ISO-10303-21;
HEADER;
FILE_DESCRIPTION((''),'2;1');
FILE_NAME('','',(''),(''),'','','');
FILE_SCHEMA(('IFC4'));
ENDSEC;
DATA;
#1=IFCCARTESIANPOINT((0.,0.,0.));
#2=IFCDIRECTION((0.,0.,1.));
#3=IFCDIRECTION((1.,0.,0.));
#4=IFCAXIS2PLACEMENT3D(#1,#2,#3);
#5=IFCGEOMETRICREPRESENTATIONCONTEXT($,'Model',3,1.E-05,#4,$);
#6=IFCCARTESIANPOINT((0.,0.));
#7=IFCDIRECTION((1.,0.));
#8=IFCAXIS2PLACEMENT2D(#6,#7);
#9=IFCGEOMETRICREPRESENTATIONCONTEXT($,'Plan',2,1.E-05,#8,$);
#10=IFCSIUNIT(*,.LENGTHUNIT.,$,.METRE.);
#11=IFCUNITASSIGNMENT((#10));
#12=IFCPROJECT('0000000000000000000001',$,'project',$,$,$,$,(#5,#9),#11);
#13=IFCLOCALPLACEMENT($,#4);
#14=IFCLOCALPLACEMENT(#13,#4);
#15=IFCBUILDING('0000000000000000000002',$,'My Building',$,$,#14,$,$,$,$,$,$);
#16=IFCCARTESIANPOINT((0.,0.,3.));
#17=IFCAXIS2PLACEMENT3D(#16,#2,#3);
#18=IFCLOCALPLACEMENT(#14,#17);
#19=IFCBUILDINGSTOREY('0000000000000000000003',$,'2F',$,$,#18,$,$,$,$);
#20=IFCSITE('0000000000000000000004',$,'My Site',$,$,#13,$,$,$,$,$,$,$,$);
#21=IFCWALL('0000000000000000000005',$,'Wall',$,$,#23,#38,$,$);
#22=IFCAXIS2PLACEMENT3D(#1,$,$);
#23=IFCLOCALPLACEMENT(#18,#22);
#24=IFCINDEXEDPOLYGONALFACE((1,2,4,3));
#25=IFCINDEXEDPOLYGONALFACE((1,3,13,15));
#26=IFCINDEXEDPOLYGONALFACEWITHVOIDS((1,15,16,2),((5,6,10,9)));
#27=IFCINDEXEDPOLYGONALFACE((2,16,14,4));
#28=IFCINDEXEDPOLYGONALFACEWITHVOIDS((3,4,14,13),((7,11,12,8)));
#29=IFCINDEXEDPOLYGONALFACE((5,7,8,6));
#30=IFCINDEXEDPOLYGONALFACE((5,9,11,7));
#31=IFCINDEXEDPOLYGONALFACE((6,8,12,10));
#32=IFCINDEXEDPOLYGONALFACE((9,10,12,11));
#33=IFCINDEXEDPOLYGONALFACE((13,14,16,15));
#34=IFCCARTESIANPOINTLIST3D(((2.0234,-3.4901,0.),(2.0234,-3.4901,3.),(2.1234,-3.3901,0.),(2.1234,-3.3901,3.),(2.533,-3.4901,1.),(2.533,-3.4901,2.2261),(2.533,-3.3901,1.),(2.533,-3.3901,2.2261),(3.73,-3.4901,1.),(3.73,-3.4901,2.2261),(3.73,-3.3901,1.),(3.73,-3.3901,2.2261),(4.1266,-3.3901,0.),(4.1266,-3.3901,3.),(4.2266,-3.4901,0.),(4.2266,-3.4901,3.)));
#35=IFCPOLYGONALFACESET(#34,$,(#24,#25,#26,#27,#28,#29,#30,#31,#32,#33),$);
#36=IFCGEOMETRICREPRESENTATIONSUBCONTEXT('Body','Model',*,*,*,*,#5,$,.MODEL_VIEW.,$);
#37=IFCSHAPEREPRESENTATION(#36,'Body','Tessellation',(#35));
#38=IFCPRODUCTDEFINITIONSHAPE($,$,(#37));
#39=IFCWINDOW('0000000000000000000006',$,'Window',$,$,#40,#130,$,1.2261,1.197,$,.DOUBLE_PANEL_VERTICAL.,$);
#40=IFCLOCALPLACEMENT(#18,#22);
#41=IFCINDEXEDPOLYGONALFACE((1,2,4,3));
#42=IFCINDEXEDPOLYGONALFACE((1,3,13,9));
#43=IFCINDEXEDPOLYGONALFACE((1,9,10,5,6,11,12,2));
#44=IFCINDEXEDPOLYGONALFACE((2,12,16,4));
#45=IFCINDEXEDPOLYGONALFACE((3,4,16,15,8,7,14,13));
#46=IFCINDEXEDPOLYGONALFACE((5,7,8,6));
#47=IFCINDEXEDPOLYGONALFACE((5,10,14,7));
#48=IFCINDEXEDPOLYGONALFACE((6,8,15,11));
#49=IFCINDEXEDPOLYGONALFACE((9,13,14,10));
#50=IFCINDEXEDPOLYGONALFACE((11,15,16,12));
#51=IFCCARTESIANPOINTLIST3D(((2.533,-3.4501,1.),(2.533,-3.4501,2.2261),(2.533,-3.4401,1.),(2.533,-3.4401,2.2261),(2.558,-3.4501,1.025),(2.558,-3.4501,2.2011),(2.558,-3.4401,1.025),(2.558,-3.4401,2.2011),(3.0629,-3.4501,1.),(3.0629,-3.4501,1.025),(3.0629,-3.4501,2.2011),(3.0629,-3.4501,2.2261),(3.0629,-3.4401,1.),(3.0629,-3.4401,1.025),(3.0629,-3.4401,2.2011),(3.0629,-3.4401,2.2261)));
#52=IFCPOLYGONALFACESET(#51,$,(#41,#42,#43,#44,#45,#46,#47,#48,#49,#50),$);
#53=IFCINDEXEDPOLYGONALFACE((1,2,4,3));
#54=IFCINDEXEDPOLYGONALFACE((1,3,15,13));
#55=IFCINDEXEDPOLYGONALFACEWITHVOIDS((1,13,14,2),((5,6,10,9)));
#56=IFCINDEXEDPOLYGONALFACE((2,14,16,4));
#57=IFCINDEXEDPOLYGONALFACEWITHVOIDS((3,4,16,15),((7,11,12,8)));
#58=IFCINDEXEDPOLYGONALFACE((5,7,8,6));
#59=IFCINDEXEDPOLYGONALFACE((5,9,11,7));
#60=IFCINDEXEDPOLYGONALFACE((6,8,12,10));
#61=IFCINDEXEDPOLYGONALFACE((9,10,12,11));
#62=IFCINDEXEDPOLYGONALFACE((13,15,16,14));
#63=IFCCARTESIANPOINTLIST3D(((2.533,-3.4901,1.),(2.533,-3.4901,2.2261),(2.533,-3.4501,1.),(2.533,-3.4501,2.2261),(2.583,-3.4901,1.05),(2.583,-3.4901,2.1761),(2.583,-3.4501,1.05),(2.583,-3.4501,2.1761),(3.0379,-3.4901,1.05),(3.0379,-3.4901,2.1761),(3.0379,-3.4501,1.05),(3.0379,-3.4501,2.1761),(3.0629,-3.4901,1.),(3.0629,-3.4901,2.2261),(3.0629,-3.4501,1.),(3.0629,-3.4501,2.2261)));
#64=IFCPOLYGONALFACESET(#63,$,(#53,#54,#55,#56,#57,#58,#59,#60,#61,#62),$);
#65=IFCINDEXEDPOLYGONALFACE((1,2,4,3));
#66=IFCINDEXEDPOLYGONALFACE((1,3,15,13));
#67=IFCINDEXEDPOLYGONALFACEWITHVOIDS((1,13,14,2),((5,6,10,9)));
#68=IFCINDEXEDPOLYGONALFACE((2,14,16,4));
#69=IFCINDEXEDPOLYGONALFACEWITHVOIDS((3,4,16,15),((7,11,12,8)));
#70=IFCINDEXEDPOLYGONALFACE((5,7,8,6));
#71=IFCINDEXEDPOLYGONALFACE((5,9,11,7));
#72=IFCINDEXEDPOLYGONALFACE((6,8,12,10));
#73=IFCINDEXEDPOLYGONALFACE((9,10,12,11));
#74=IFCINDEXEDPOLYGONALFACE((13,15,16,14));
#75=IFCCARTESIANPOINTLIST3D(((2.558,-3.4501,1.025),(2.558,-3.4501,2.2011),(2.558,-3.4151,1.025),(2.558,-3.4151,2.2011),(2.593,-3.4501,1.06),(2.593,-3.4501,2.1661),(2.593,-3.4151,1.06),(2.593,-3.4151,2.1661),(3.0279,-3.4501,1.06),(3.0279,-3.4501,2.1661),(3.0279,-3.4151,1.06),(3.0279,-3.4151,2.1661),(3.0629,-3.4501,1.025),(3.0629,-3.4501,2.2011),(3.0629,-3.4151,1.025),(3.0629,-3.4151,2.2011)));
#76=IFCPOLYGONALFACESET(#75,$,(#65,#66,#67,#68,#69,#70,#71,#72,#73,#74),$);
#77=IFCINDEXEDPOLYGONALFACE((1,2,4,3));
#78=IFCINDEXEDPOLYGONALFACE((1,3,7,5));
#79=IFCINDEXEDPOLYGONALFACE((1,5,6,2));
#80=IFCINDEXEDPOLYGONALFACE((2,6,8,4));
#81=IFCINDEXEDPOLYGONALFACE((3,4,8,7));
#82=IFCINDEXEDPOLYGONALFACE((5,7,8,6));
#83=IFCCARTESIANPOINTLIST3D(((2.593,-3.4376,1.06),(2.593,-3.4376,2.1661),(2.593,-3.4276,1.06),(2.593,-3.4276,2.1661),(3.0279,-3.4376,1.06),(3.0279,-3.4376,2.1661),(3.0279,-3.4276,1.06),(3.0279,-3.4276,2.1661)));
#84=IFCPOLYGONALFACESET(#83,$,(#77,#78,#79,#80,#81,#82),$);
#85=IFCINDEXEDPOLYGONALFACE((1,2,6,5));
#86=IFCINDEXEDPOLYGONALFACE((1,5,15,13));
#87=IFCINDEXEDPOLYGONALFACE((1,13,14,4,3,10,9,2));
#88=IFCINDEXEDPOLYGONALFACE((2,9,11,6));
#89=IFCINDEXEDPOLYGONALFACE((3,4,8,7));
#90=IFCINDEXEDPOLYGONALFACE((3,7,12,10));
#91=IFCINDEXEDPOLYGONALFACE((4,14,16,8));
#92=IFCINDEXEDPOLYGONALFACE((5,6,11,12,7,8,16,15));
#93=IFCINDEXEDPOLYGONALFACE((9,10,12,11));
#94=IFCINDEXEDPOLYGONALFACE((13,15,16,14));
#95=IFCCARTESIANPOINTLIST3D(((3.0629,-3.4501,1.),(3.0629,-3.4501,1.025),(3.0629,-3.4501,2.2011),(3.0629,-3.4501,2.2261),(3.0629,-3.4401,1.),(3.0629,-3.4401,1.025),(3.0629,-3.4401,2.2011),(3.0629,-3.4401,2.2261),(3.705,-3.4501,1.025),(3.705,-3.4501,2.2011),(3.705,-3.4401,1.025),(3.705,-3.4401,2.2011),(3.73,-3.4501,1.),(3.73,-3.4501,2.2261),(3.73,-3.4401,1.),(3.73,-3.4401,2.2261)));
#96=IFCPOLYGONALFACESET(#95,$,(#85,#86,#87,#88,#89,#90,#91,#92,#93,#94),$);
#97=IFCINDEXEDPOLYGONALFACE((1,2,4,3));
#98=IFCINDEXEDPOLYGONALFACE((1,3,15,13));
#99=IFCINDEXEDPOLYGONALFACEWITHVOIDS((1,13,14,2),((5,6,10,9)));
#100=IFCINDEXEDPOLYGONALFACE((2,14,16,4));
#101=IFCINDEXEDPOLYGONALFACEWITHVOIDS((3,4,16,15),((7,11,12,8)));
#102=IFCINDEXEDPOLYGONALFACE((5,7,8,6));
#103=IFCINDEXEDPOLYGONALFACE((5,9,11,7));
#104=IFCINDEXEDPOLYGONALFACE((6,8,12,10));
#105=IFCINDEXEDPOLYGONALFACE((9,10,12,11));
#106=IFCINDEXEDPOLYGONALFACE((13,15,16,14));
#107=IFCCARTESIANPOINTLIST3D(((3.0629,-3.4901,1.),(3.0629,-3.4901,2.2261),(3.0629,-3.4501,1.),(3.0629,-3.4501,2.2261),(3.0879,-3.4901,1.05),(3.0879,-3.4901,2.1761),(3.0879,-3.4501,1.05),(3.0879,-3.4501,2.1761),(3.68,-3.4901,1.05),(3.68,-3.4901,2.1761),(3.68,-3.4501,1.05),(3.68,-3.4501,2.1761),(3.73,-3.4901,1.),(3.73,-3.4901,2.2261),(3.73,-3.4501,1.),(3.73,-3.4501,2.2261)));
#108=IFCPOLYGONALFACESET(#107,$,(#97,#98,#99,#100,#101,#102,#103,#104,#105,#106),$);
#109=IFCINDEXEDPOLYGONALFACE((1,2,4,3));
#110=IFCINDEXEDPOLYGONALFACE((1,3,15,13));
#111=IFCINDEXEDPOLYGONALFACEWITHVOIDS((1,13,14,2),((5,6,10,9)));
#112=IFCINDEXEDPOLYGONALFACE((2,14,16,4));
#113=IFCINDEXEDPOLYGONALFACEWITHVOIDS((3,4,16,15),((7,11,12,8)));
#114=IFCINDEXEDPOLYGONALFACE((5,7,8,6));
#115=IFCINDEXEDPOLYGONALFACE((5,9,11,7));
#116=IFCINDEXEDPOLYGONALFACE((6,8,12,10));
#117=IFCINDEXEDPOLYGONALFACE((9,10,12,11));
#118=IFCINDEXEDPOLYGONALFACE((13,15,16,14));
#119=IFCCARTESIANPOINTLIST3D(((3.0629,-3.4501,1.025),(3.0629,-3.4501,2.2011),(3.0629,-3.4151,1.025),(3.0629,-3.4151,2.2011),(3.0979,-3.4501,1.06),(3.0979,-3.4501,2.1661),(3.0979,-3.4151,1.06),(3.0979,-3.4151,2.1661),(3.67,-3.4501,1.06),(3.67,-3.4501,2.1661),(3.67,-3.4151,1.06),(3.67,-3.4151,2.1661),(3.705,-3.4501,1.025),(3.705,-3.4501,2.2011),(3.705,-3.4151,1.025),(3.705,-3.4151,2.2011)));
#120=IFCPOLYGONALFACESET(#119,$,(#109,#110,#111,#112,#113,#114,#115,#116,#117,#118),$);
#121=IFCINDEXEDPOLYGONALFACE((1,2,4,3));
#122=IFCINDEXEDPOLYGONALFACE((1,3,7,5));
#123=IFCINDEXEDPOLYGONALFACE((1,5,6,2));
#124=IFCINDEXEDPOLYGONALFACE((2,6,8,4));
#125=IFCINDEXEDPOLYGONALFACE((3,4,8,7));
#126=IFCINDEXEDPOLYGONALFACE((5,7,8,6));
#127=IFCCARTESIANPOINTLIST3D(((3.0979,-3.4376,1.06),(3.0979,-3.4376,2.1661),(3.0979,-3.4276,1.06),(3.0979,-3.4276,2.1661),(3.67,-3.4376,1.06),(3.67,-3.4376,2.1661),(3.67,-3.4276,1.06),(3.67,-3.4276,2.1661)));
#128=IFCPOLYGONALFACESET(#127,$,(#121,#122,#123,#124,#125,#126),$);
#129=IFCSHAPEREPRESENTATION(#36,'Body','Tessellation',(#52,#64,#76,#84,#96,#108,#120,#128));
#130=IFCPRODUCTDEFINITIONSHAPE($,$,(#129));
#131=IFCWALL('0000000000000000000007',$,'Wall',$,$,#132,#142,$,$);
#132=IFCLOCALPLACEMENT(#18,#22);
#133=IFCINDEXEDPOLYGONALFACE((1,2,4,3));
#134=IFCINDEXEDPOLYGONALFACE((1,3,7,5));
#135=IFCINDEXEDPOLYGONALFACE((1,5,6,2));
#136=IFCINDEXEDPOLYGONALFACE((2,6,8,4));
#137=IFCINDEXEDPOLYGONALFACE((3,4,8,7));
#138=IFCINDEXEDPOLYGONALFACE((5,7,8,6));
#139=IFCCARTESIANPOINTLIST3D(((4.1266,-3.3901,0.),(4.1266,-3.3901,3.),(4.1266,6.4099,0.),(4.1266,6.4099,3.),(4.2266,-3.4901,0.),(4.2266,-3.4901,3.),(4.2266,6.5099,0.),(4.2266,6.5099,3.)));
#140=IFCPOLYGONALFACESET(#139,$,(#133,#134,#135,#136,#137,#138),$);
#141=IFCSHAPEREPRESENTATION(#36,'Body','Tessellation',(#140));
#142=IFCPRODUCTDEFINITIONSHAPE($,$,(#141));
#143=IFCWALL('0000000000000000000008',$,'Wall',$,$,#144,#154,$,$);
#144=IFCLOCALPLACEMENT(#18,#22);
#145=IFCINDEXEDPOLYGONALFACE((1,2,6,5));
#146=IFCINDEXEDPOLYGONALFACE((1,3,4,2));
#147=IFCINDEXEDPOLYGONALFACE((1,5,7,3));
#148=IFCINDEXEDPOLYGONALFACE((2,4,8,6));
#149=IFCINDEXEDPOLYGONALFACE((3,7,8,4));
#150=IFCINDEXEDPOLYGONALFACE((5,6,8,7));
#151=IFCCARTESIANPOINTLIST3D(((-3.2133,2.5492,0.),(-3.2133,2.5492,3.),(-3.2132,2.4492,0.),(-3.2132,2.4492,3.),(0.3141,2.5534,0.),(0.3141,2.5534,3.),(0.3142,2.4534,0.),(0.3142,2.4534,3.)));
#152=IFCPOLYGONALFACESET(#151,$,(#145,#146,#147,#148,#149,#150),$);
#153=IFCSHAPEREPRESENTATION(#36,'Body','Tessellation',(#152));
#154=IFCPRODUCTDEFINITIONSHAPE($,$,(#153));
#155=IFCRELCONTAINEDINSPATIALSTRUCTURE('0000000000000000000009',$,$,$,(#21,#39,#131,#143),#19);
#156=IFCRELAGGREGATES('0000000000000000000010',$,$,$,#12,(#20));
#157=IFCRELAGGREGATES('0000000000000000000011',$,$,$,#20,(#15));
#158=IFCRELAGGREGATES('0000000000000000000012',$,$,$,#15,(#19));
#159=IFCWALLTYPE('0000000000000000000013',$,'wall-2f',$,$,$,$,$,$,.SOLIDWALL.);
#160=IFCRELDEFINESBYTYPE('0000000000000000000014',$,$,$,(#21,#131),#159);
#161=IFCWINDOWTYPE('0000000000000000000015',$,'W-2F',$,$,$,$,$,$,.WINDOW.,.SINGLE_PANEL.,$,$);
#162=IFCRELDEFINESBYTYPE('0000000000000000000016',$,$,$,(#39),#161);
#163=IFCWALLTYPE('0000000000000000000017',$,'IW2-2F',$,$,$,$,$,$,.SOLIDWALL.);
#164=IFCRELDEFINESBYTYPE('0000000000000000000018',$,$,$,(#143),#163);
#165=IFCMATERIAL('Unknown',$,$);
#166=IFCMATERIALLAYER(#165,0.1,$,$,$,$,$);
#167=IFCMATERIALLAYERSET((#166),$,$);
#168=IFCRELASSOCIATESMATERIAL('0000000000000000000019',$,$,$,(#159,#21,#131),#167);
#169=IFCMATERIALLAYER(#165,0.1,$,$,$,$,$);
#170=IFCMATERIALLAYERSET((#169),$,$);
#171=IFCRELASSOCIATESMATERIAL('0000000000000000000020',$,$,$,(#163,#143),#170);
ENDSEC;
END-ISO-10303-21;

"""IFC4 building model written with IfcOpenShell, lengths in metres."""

from ifc_helpers import new_model, entity, si_unit, frame, origin_with_axes, origin_2d_with_axis, place, context, subcontext, project, spatial, line, indexed_curve, outline, extrude, shape, source, transform, mapped, material, layer, layer_set, layer_usage, type_object, type_shapes, element, fill, save


model = new_model("IFC4")

# Units and contexts
model_context = context("Model", 3, precision=1e-05, world=origin_with_axes())
plan_context = context("Plan", 2, precision=1e-05, world=origin_2d_with_axis())
body_context_1 = subcontext(model_context, "Body", "Model", "MODEL_VIEW")
body_context_2 = subcontext(plan_context, "Body", "Plan", "PLAN_VIEW")
ifc_project = project(units=[si_unit("LENGTHUNIT", "METRE")], contexts=[model_context, plan_context])

# Site, building, storey
site_placement = place(None, origin_with_axes())
site = spatial("IfcSite", under=ifc_project, at=site_placement, Name="My Site")
building_placement = place(site_placement, origin_with_axes())
building = spatial("IfcBuilding", under=site, at=building_placement, Name="My Building")
storey_placement = place(building_placement, frame((0.0, 0.0, 3.0), z_axis=(0.0, 0.0, 1.0), x_axis=(1.0, 0.0, 0.0)))
storey = spatial("IfcBuildingStorey", under=building, at=storey_placement, Name="2F")

# Shared definitions
ifc_material = material(Name="Unknown")
ifc_layer_1 = layer(ifc_material, 0.1)
ifc_layer_set_1 = layer_set([ifc_layer_1])
wall_type_1 = type_object("IfcWallType", Name="wall-2f", PredefinedType="SOLIDWALL", material=ifc_layer_set_1)

# Wall, opening, window
ifc_layer_usage_1 = layer_usage(ifc_layer_set_1, "AXIS2", "POSITIVE", 0.0)
wall_1_placement = place(storey_placement, frame((2.0234, -3.4901, 0.0), z_axis=(0.0, 0.0, 1.0), x_axis=(1.0, 0.0, 0.0)))
wall_1 = element("IfcWall", 1, at=wall_1_placement, inside=storey, type_object=wall_type_1, material=ifc_layer_usage_1, Name="Wall", context=body_context_1, shape_type="SweptSolid", body=[
    extrude(outline(indexed_curve([(0.0, 0.0), (0.1, 0.1), (2.1032, 0.1), (2.2032, 0.0)], segments=[line(1, 2, 3, 4, 1)])), origin_with_axes(), (0.0, 0.0, 1.0), 3.0),
])
shared_shape_1 = source(origin_with_axes(), body_context_1, "Body", "SweptSolid", [
    extrude(outline(indexed_curve([(0.0, 0.0), (1.197, 0.0), (1.197, 1.2261), (0.0, 1.2261)], segments=[line(1, 2, 3, 4, 1)])), frame((0.0, -0.6, 0.0), z_axis=(0.0, -1.0, 0.0), x_axis=(1.0, 0.0, 0.0)), (0.0, 0.0, -1.0), 1.2),
])
opening_1_placement = place(wall_1_placement, frame((0.5096, -0.05, 1.0), z_axis=(0.0, 0.0, 1.0), x_axis=(1.0, 0.0, 0.0)))
opening_1 = element("IfcOpeningElement", 2, at=opening_1_placement, cuts=wall_1, PredefinedType="OPENING", context=body_context_1, shape_type="MappedRepresentation", body=[
    mapped(shared_shape_1, transform((0.0, 0.0, 0.0), x_axis=(1.0, 0.0, 0.0), y_axis=(0.0, 1.0, 0.0), z_axis=(0.0, 0.0, 1.0), scale=1.0)),
])
window_type_1 = type_object("IfcWindowType", Name="W-2F", PartitioningType="SINGLE_PANEL", PredefinedType="WINDOW")
shared_shape_2 = source(origin_with_axes(), body_context_1, "Body", "SweptSolid", [
    extrude(outline(indexed_curve([(0.5299, 0.0), (0.0, 0.0), (0.0, 1.2261), (0.5299, 1.2261), (0.5299, 1.2011), (0.025, 1.2011), (0.025, 0.025), (0.5299, 0.025)], segments=[line(1, 2, 3, 4, 5, 6, 7, 8, 1)])), frame((0.0, 0.09, 0.0), z_axis=(0.0, -1.0, 0.0), x_axis=(1.0, 0.0, 0.0)), (0.0, 0.0, -1.0), 0.01),
    extrude(outline(indexed_curve([(0.0, 0.0), (0.5299, 0.0), (0.5299, 1.2261), (0.0, 1.2261)], segments=[line(1, 2, 3, 4, 1)]), holes=[indexed_curve([(0.05, 0.05), (0.5049, 0.05), (0.5049, 1.1761), (0.05, 1.1761)], segments=[line(1, 2, 3, 4, 1)])]), frame((0.0, 0.05, 0.0), z_axis=(0.0, -1.0, 0.0), x_axis=(1.0, 0.0, 0.0)), (0.0, 0.0, -1.0), 0.04),
    extrude(outline(indexed_curve([(0.0, 0.0), (0.5049, 0.0), (0.5049, 1.1761), (0.0, 1.1761)], segments=[line(1, 2, 3, 4, 1)]), holes=[indexed_curve([(0.035, 0.035), (0.4699, 0.035), (0.4699, 1.1411), (0.035, 1.1411)], segments=[line(1, 2, 3, 4, 1)])]), frame((0.025, 0.09, 0.025), z_axis=(0.0, -1.0, 0.0), x_axis=(1.0, 0.0, 0.0)), (0.0, 0.0, -1.0), 0.035),
    extrude(outline(indexed_curve([(0.035, 0.035), (0.4699, 0.035), (0.4699, 1.1411), (0.035, 1.1411)], segments=[line(1, 2, 3, 4, 1)])), frame((0.025, 0.1025, 0.025), z_axis=(0.0, -1.0, 0.0), x_axis=(1.0, 0.0, 0.0)), (0.0, 0.0, -1.0), 0.01),
    extrude(outline(indexed_curve([(0.0, 1.2261), (0.6671, 1.2261), (0.6671, 0.0), (0.0, 0.0), (0.0, 0.025), (0.6421, 0.025), (0.6421, 1.2011), (0.0, 1.2011)], segments=[line(1, 2, 3, 4, 5, 6, 7, 8, 1)])), frame((0.5299, 0.09, 0.0), z_axis=(0.0, -1.0, 0.0), x_axis=(1.0, 0.0, 0.0)), (0.0, 0.0, -1.0), 0.01),
    extrude(outline(indexed_curve([(0.0, 0.0), (0.6671, 0.0), (0.6671, 1.2261), (0.0, 1.2261)], segments=[line(1, 2, 3, 4, 1)]), holes=[indexed_curve([(0.025, 0.05), (0.6171, 0.05), (0.6171, 1.1761), (0.025, 1.1761)], segments=[line(1, 2, 3, 4, 1)])]), frame((0.5299, 0.05, 0.0), z_axis=(0.0, -1.0, 0.0), x_axis=(1.0, 0.0, 0.0)), (0.0, 0.0, -1.0), 0.04),
    extrude(outline(indexed_curve([(0.0, 0.0), (0.6421, 0.0), (0.6421, 1.1761), (0.0, 1.1761)], segments=[line(1, 2, 3, 4, 1)]), holes=[indexed_curve([(0.035, 0.035), (0.6071, 0.035), (0.6071, 1.1411), (0.035, 1.1411)], segments=[line(1, 2, 3, 4, 1)])]), frame((0.5299, 0.09, 0.025), z_axis=(0.0, -1.0, 0.0), x_axis=(1.0, 0.0, 0.0)), (0.0, 0.0, -1.0), 0.035),
    extrude(outline(indexed_curve([(0.035, 0.035), (0.6071, 0.035), (0.6071, 1.1411), (0.035, 1.1411)], segments=[line(1, 2, 3, 4, 1)])), frame((0.5299, 0.1025, 0.025), z_axis=(0.0, -1.0, 0.0), x_axis=(1.0, 0.0, 0.0)), (0.0, 0.0, -1.0), 0.01),
])
shared_shape_3 = source(origin_with_axes(), body_context_2, "Body", "Curve2D", [
    entity("IfcIndexedPolyCurve", entity("IfcCartesianPointList2D", [[0.05, 0.05], [0.5049, 0.05]])),
    entity("IfcIndexedPolyCurve", entity("IfcCartesianPointList2D", [[0.0, 0.1], [0.025, 0.1], [0.025, 0.09], [0.05, 0.09], [0.05, 0.05], [0.0, 0.05]]), [entity("IfcLineIndex", [1, 2, 3, 4, 5, 6, 1])]),
    entity("IfcIndexedPolyCurve", entity("IfcCartesianPointList2D", [[0.5299, 0.1], [0.5299, 0.1], [0.5299, 0.09], [0.5049, 0.09], [0.5049, 0.05], [0.5299, 0.05]])),
    entity("IfcIndexedPolyCurve", entity("IfcCartesianPointList2D", [[0.025, 0.09], [0.06, 0.09], [0.06, 0.125], [0.025, 0.125]]), [entity("IfcLineIndex", [1, 2, 3, 4, 1])]),
    entity("IfcIndexedPolyCurve", entity("IfcCartesianPointList2D", [[0.5299, 0.09], [0.4949, 0.09], [0.4949, 0.125], [0.5299, 0.125]]), [entity("IfcLineIndex", [1, 2, 3, 4, 1])]),
    entity("IfcIndexedPolyCurve", entity("IfcCartesianPointList2D", [[0.06, 0.09], [0.4949, 0.09]])),
    entity("IfcIndexedPolyCurve", entity("IfcCartesianPointList2D", [[0.06, 0.125], [0.4949, 0.125]])),
    entity("IfcIndexedPolyCurve", entity("IfcCartesianPointList2D", [[0.06, 0.1075], [0.4949, 0.1075]])),
    entity("IfcIndexedPolyCurve", entity("IfcCartesianPointList2D", [[0.5549, 0.05], [1.147, 0.05]])),
    entity("IfcIndexedPolyCurve", entity("IfcCartesianPointList2D", [[0.5299, 0.1], [0.5299, 0.1], [0.5299, 0.09], [0.5549, 0.09], [0.5549, 0.05], [0.5299, 0.05]])),
    entity("IfcIndexedPolyCurve", entity("IfcCartesianPointList2D", [[1.197, 0.1], [1.172, 0.1], [1.172, 0.09], [1.147, 0.09], [1.147, 0.05], [1.197, 0.05]]), [entity("IfcLineIndex", [1, 2, 3, 4, 5, 6, 1])]),
    entity("IfcIndexedPolyCurve", entity("IfcCartesianPointList2D", [[0.5299, 0.09], [0.5649, 0.09], [0.5649, 0.125], [0.5299, 0.125]]), [entity("IfcLineIndex", [1, 2, 3, 4, 1])]),
    entity("IfcIndexedPolyCurve", entity("IfcCartesianPointList2D", [[1.172, 0.09], [1.137, 0.09], [1.137, 0.125], [1.172, 0.125]]), [entity("IfcLineIndex", [1, 2, 3, 4, 1])]),
    entity("IfcIndexedPolyCurve", entity("IfcCartesianPointList2D", [[0.5649, 0.09], [1.137, 0.09]])),
    entity("IfcIndexedPolyCurve", entity("IfcCartesianPointList2D", [[0.5649, 0.125], [1.137, 0.125]])),
    entity("IfcIndexedPolyCurve", entity("IfcCartesianPointList2D", [[0.5649, 0.1075], [1.137, 0.1075]])),
])
type_shapes(window_type_1, [shared_shape_2, shared_shape_3])
window_1_placement = place(opening_1_placement, frame((0.0, 0.0, 0.0), z_axis=(0.0, 0.0, 1.0), x_axis=(1.0, 0.0, 0.0)))
window_1 = element("IfcWindow", 3, at=window_1_placement, inside=storey, type_object=window_type_1, Name="Window", OverallHeight=1.2261, OverallWidth=1.197, PartitioningType="DOUBLE_PANEL_VERTICAL", shapes=[
    shape(body_context_1, "Body", "MappedRepresentation", [mapped(shared_shape_2, transform((0.0, 0.0, 0.0), x_axis=(1.0, 0.0, 0.0), y_axis=(0.0, 1.0, 0.0), z_axis=(0.0, 0.0, 1.0), scale=1.0))]),
    shape(body_context_2, "Body", "MappedRepresentation", [mapped(shared_shape_3, transform((0.0, 0.0, 0.0), x_axis=(1.0, 0.0, 0.0), y_axis=(0.0, 1.0, 0.0), z_axis=(0.0, 0.0, 1.0), scale=1.0))]),
])
fill(opening_1, window_1)

# Wall
ifc_layer_usage_2 = layer_usage(ifc_layer_set_1, "AXIS2", "POSITIVE", 0.0)
wall_2_placement = place(storey_placement, frame((4.2266, -3.4901, 0.0), z_axis=(0.0, 0.0, 1.0), x_axis=(0.0, 1.0, 0.0)))
element("IfcWall", 4, at=wall_2_placement, inside=storey, type_object=wall_type_1, material=ifc_layer_usage_2, Name="Wall", context=body_context_1, shape_type="SweptSolid", body=[
    extrude(outline(indexed_curve([(0.0, 0.0), (0.1, 0.1), (9.9, 0.1), (10.0, 0.0)], segments=[line(1, 2, 3, 4, 1)])), origin_with_axes(), (0.0, 0.0, 1.0), 3.0),
])

# Shared definitions
ifc_layer_2 = layer(ifc_material, 0.1)
ifc_layer_set_2 = layer_set([ifc_layer_2])
wall_type_2 = type_object("IfcWallType", Name="IW2-2F", PredefinedType="SOLIDWALL", material=ifc_layer_set_2)

# Wall
ifc_layer_usage_3 = layer_usage(ifc_layer_set_2, "AXIS2", "POSITIVE", 0.0)
wall_3_placement = place(storey_placement, frame((-3.2132, 2.4492, 0.0), z_axis=(0.0, 0.0, 1.0), x_axis=(0.999999, 0.001175, 0.0)))
element("IfcWall", 5, at=wall_3_placement, inside=storey, type_object=wall_type_2, material=ifc_layer_usage_3, Name="Wall", context=body_context_1, shape_type="SweptSolid", body=[
    extrude(outline(indexed_curve([(0.0, 0.0), (0.0, 0.1), (3.5275, 0.1), (3.5275, 0.0)], segments=[line(1, 2, 3, 4, 1)])), origin_with_axes(), (0.0, 0.0, 1.0), 3.0),
])

save(model, "model.ifc")
